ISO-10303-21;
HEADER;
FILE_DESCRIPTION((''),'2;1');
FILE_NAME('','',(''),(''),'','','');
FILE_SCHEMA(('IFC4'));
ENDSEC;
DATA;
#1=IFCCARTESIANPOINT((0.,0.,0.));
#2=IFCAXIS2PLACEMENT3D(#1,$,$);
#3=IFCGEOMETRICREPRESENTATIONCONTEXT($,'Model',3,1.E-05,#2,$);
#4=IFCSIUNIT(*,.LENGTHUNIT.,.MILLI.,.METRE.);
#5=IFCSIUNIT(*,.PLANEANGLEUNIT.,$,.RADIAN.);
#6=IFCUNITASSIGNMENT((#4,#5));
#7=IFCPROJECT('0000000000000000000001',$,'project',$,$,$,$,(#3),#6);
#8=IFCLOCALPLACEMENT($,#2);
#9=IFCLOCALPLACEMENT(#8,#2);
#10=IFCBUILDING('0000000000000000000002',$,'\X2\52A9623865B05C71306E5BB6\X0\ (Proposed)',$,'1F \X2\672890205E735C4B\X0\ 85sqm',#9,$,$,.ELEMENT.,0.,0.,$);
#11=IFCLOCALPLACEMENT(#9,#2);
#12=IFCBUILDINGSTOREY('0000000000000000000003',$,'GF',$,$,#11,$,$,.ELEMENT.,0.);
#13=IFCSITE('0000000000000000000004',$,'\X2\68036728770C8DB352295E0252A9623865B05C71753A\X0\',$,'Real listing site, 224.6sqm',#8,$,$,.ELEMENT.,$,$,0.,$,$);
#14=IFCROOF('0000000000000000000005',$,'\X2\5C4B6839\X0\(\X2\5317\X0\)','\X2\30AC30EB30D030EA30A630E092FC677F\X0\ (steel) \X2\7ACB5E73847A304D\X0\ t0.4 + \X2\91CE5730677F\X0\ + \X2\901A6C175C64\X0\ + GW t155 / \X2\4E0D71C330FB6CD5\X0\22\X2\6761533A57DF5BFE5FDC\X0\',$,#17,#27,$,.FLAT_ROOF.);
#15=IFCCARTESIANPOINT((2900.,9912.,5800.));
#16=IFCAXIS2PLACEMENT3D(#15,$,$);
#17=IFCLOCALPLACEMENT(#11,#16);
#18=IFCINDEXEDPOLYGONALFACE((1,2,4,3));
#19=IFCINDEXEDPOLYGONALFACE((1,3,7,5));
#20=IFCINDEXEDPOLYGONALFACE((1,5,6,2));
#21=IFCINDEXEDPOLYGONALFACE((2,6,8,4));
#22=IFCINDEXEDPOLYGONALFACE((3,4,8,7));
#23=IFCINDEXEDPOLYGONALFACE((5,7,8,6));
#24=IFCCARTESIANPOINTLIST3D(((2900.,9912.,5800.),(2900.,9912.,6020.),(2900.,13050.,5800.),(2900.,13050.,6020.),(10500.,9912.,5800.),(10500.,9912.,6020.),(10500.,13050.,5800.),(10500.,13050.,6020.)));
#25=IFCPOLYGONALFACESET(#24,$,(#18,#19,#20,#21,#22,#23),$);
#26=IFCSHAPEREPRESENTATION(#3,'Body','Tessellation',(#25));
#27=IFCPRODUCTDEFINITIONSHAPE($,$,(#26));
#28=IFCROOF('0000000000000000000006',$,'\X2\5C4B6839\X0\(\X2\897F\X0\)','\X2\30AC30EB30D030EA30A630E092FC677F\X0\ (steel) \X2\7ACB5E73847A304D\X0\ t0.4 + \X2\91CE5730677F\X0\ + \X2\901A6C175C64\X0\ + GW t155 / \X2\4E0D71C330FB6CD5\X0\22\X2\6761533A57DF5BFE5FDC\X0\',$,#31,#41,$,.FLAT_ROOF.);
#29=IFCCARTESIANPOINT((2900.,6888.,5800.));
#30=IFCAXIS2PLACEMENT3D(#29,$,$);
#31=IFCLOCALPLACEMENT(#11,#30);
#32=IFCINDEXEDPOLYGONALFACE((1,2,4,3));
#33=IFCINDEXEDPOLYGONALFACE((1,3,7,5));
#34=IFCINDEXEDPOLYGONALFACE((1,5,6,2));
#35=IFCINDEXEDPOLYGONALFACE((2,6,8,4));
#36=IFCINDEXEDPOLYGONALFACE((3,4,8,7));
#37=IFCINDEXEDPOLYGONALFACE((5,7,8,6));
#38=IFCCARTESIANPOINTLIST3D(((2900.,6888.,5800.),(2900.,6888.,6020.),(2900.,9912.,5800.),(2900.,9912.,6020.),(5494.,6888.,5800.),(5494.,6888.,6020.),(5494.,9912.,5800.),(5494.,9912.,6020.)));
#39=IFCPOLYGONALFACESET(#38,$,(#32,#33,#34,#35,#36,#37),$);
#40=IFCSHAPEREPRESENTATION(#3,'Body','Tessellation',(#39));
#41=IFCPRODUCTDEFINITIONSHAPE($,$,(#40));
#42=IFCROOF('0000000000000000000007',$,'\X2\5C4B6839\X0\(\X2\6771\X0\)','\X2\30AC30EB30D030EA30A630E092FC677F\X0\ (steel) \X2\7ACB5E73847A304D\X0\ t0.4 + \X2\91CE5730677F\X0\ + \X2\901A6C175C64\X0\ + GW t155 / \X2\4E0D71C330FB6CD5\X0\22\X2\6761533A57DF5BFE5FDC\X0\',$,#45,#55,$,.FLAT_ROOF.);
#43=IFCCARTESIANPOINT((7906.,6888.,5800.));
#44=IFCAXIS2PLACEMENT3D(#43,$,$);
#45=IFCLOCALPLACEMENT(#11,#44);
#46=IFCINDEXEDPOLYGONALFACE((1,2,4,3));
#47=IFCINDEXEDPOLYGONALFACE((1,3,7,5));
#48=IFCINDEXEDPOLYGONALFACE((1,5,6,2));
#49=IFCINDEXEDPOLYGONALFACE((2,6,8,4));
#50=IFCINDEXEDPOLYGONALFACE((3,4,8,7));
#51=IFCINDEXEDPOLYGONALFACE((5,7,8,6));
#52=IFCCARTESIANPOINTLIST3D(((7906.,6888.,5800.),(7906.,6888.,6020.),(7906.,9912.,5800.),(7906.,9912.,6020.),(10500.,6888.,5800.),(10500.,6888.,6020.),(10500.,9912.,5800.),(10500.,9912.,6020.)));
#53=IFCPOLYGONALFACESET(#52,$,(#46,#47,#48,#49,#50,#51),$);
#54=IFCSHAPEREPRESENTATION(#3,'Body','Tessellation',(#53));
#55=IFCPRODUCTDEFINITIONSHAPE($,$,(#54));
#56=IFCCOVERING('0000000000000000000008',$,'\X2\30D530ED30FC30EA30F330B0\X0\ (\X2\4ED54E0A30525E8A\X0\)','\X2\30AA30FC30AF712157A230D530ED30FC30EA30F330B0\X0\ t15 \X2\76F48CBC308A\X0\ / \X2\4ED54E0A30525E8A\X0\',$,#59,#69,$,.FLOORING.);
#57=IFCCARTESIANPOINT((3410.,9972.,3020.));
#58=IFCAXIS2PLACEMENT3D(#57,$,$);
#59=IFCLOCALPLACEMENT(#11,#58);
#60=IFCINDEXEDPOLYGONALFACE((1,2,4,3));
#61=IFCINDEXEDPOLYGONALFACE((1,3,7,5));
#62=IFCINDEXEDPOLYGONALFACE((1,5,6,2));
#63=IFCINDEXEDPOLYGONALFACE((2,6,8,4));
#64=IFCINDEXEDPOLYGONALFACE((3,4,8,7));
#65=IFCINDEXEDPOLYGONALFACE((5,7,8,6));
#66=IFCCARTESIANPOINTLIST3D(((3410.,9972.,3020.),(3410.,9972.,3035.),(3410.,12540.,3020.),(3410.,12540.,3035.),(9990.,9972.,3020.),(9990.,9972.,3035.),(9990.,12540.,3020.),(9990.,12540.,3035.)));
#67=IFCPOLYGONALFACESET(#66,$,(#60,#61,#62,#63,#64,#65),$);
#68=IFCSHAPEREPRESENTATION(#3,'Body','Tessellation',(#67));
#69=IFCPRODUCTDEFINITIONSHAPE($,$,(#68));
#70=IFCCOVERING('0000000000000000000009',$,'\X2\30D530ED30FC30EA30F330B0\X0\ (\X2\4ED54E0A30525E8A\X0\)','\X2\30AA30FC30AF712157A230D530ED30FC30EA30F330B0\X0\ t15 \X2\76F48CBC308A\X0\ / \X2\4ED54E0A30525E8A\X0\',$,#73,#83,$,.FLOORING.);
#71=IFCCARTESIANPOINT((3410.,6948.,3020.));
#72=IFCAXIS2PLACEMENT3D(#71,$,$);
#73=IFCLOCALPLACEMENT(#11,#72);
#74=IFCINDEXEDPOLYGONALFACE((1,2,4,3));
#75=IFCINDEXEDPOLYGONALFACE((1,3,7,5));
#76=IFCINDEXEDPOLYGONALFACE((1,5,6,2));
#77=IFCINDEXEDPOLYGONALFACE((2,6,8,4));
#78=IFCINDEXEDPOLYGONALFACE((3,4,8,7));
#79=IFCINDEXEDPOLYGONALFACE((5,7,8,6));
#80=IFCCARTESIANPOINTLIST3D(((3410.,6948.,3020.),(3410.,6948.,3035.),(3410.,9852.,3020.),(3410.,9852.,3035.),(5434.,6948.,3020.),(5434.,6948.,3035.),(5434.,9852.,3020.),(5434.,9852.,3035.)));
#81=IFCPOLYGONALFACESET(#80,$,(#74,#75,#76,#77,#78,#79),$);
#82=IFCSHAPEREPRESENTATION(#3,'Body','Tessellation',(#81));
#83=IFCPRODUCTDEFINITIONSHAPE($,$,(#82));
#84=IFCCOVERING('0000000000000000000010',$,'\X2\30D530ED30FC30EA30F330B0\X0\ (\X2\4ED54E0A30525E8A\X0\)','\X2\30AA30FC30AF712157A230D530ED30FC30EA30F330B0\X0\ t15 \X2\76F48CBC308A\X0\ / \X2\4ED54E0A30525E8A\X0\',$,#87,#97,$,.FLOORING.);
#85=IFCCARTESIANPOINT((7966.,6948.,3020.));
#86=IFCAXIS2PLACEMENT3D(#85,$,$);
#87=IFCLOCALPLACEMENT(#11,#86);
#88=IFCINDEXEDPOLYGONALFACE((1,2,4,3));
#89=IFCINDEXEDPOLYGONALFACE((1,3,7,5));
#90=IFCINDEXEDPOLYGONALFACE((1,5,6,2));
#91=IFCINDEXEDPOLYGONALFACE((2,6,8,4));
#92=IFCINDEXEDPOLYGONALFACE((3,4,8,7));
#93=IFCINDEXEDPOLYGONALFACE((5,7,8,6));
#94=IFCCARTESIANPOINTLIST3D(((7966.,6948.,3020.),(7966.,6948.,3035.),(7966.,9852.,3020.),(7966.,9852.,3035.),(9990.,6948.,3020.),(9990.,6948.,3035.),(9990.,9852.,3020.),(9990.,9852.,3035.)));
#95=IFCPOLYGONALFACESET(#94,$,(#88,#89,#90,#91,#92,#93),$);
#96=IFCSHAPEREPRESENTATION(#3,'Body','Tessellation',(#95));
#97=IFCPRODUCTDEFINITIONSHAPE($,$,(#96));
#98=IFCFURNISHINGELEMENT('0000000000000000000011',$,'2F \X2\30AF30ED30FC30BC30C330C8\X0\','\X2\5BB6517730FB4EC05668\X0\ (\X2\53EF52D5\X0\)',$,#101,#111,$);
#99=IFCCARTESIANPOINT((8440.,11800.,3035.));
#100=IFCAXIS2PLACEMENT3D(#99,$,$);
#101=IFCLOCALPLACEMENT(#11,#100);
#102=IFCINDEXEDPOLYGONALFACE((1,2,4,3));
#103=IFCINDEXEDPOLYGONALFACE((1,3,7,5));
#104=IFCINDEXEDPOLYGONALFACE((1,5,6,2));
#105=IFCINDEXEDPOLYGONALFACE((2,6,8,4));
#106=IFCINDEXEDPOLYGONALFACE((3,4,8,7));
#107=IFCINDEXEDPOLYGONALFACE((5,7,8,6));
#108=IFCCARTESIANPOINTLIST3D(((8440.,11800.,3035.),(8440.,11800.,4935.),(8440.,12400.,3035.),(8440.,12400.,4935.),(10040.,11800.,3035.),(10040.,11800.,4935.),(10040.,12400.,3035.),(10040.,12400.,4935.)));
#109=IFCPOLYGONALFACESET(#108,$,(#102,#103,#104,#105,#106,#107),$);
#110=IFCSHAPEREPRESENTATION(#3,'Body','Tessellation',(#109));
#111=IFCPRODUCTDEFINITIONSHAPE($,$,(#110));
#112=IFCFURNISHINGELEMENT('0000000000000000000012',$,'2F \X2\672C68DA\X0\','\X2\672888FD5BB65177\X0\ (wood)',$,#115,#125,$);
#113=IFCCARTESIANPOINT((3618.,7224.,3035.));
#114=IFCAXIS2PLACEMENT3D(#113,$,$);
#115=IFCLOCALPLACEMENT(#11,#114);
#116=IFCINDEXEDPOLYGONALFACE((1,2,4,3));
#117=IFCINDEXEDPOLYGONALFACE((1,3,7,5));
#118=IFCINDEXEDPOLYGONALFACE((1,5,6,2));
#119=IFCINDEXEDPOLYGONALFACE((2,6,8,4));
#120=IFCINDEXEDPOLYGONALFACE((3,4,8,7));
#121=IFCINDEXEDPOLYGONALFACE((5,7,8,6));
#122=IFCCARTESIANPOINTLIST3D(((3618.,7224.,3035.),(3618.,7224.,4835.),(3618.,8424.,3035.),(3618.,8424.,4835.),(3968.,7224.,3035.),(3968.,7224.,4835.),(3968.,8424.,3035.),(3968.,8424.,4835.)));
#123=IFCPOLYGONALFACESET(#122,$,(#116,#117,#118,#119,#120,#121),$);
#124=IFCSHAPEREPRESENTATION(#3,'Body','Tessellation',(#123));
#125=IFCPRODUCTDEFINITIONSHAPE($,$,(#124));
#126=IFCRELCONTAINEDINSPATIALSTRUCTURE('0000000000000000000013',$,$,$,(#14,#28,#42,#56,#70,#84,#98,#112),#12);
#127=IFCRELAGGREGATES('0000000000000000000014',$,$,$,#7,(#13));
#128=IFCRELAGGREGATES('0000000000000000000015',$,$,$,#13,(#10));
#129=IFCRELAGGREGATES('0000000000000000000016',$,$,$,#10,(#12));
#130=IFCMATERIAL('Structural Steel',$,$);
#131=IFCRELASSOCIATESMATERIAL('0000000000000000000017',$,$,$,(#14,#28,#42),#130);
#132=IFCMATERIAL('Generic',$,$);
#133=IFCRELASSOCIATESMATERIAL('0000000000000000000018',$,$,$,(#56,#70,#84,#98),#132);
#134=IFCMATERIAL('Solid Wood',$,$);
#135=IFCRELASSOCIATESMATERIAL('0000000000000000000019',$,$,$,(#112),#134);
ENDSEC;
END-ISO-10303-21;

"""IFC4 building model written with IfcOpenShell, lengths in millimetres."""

from ifc_helpers import new_model, si_unit, frame, frame_2d, origin, place, context, project, spatial, rectangle, extrude, material, element, save


model = new_model("IFC4")

# Units and contexts
model_context = context("Model", 3, precision=1e-05, world=origin())
ifc_project = project(units=[si_unit("LENGTHUNIT", "METRE", prefix="MILLI"), si_unit("PLANEANGLEUNIT", "RADIAN")], contexts=[model_context])

# Site, building, storey
site_placement = place(None, origin())
site = spatial("IfcSite", under=ifc_project, at=site_placement, Name="栃木県足利市助戸新山町", ObjectType="Real listing site, 224.6sqm", CompositionType="ELEMENT", RefElevation=0.0)
building_placement = place(site_placement, origin())
building = spatial("IfcBuilding", under=site, at=building_placement, Name="助戸新山の家 (Proposed)", ObjectType="1F 木造平屋 85sqm", CompositionType="ELEMENT", ElevationOfRefHeight=0.0, ElevationOfTerrain=0.0)
storey_placement = place(building_placement, origin())
storey = spatial("IfcBuildingStorey", under=building, at=storey_placement, Name="GF", CompositionType="ELEMENT", Elevation=0.0)

# Shared definitions
ifc_material_1 = material(Name="Solid Wood")

# Shared definitions
ifc_material_2 = material(Name="Generic")

# Roofs
ifc_material_3 = material(Name="Structural Steel")
for number, where, name in (
    (1, (2900.0, 9912.0, 5800.0), "屋根(北)"),
):
    element("IfcRoof", number, at=place(storey_placement, frame(where)), inside=storey, material=ifc_material_3, Name=name, Description="ガルバリウム鋼板 (steel) 立平葺き t0.4 + 野地板 + 通気層 + GW t155 / 不燃・法22条区域対応", PredefinedType="FLAT_ROOF", context=model_context, shape_type="SweptSolid", body=[
        extrude(rectangle(XDim=7600.0, YDim=3138.0, at=frame_2d((3800.0, 1569.0))), frame((2900.0, 9912.0, 5800.0)), (0.0, 0.0, 1.0), 220.0),
    ])
roof_1_placement = place(storey_placement, frame((2900.0, 6888.0, 5800.0)))
element("IfcRoof", 2, at=roof_1_placement, inside=storey, material=ifc_material_3, Name="屋根(西)", Description="ガルバリウム鋼板 (steel) 立平葺き t0.4 + 野地板 + 通気層 + GW t155 / 不燃・法22条区域対応", PredefinedType="FLAT_ROOF", context=model_context, shape_type="SweptSolid", body=[
    extrude(rectangle(XDim=2594.0, YDim=3024.0, at=frame_2d((1297.0, 1512.0))), frame((2900.0, 6888.0, 5800.0)), (0.0, 0.0, 1.0), 220.0),
])
roof_2_placement = place(storey_placement, frame((7906.0, 6888.0, 5800.0)))
element("IfcRoof", 3, at=roof_2_placement, inside=storey, material=ifc_material_3, Name="屋根(東)", Description="ガルバリウム鋼板 (steel) 立平葺き t0.4 + 野地板 + 通気層 + GW t155 / 不燃・法22条区域対応", PredefinedType="FLAT_ROOF", context=model_context, shape_type="SweptSolid", body=[
    extrude(rectangle(XDim=2594.0, YDim=3024.0, at=frame_2d((1297.0, 1512.0))), frame((7906.0, 6888.0, 5800.0)), (0.0, 0.0, 1.0), 220.0),
])

# Coverings
covering_1_placement = place(storey_placement, frame((3410.0, 9972.0, 3020.0)))
element("IfcCovering", 4, at=covering_1_placement, inside=storey, material=ifc_material_2, Name="フローリング (仕上げ床)", Description="オーク無垢フローリング t15 直貼り / 仕上げ床", PredefinedType="FLOORING", context=model_context, shape_type="SweptSolid", body=[
    extrude(rectangle(XDim=6580.0, YDim=2568.0, at=frame_2d((3290.0, 1284.0))), frame((3410.0, 9972.0, 3020.0)), (0.0, 0.0, 1.0), 15.0),
])
covering_2_placement = place(storey_placement, frame((3410.0, 6948.0, 3020.0)))
element("IfcCovering", 5, at=covering_2_placement, inside=storey, material=ifc_material_2, Name="フローリング (仕上げ床)", Description="オーク無垢フローリング t15 直貼り / 仕上げ床", PredefinedType="FLOORING", context=model_context, shape_type="SweptSolid", body=[
    extrude(rectangle(XDim=2024.0, YDim=2904.0, at=frame_2d((1012.0, 1452.0))), frame((3410.0, 6948.0, 3020.0)), (0.0, 0.0, 1.0), 15.0),
])
covering_3_placement = place(storey_placement, frame((7966.0, 6948.0, 3020.0)))
element("IfcCovering", 6, at=covering_3_placement, inside=storey, material=ifc_material_2, Name="フローリング (仕上げ床)", Description="オーク無垢フローリング t15 直貼り / 仕上げ床", PredefinedType="FLOORING", context=model_context, shape_type="SweptSolid", body=[
    extrude(rectangle(XDim=2024.0, YDim=2904.0, at=frame_2d((1012.0, 1452.0))), frame((7966.0, 6948.0, 3020.0)), (0.0, 0.0, 1.0), 15.0),
])

# Furnishing elements
furnishing_1_placement = place(storey_placement, frame((8440.0, 11800.0, 3035.0)))
element("IfcFurnishingElement", 7, at=furnishing_1_placement, inside=storey, material=ifc_material_2, Name="2F クローゼット", Description="家具・什器 (可動)", context=model_context, shape_type="SweptSolid", body=[
    extrude(rectangle(XDim=1600.0, YDim=600.0, at=frame_2d((800.0, 300.0))), frame((8440.0, 11800.0, 3035.0)), (0.0, 0.0, 1.0), 1900.0),
])
furnishing_2_placement = place(storey_placement, frame((3618.0, 7224.0, 3035.0)))
element("IfcFurnishingElement", 8, at=furnishing_2_placement, inside=storey, material=ifc_material_1, Name="2F 本棚", Description="木製家具 (wood)", context=model_context, shape_type="SweptSolid", body=[
    extrude(rectangle(XDim=350.0, YDim=1200.0, at=frame_2d((175.0, 600.0))), frame((3618.0, 7224.0, 3035.0)), (0.0, 0.0, 1.0), 1800.0),
])

save(model, "model.ifc")
